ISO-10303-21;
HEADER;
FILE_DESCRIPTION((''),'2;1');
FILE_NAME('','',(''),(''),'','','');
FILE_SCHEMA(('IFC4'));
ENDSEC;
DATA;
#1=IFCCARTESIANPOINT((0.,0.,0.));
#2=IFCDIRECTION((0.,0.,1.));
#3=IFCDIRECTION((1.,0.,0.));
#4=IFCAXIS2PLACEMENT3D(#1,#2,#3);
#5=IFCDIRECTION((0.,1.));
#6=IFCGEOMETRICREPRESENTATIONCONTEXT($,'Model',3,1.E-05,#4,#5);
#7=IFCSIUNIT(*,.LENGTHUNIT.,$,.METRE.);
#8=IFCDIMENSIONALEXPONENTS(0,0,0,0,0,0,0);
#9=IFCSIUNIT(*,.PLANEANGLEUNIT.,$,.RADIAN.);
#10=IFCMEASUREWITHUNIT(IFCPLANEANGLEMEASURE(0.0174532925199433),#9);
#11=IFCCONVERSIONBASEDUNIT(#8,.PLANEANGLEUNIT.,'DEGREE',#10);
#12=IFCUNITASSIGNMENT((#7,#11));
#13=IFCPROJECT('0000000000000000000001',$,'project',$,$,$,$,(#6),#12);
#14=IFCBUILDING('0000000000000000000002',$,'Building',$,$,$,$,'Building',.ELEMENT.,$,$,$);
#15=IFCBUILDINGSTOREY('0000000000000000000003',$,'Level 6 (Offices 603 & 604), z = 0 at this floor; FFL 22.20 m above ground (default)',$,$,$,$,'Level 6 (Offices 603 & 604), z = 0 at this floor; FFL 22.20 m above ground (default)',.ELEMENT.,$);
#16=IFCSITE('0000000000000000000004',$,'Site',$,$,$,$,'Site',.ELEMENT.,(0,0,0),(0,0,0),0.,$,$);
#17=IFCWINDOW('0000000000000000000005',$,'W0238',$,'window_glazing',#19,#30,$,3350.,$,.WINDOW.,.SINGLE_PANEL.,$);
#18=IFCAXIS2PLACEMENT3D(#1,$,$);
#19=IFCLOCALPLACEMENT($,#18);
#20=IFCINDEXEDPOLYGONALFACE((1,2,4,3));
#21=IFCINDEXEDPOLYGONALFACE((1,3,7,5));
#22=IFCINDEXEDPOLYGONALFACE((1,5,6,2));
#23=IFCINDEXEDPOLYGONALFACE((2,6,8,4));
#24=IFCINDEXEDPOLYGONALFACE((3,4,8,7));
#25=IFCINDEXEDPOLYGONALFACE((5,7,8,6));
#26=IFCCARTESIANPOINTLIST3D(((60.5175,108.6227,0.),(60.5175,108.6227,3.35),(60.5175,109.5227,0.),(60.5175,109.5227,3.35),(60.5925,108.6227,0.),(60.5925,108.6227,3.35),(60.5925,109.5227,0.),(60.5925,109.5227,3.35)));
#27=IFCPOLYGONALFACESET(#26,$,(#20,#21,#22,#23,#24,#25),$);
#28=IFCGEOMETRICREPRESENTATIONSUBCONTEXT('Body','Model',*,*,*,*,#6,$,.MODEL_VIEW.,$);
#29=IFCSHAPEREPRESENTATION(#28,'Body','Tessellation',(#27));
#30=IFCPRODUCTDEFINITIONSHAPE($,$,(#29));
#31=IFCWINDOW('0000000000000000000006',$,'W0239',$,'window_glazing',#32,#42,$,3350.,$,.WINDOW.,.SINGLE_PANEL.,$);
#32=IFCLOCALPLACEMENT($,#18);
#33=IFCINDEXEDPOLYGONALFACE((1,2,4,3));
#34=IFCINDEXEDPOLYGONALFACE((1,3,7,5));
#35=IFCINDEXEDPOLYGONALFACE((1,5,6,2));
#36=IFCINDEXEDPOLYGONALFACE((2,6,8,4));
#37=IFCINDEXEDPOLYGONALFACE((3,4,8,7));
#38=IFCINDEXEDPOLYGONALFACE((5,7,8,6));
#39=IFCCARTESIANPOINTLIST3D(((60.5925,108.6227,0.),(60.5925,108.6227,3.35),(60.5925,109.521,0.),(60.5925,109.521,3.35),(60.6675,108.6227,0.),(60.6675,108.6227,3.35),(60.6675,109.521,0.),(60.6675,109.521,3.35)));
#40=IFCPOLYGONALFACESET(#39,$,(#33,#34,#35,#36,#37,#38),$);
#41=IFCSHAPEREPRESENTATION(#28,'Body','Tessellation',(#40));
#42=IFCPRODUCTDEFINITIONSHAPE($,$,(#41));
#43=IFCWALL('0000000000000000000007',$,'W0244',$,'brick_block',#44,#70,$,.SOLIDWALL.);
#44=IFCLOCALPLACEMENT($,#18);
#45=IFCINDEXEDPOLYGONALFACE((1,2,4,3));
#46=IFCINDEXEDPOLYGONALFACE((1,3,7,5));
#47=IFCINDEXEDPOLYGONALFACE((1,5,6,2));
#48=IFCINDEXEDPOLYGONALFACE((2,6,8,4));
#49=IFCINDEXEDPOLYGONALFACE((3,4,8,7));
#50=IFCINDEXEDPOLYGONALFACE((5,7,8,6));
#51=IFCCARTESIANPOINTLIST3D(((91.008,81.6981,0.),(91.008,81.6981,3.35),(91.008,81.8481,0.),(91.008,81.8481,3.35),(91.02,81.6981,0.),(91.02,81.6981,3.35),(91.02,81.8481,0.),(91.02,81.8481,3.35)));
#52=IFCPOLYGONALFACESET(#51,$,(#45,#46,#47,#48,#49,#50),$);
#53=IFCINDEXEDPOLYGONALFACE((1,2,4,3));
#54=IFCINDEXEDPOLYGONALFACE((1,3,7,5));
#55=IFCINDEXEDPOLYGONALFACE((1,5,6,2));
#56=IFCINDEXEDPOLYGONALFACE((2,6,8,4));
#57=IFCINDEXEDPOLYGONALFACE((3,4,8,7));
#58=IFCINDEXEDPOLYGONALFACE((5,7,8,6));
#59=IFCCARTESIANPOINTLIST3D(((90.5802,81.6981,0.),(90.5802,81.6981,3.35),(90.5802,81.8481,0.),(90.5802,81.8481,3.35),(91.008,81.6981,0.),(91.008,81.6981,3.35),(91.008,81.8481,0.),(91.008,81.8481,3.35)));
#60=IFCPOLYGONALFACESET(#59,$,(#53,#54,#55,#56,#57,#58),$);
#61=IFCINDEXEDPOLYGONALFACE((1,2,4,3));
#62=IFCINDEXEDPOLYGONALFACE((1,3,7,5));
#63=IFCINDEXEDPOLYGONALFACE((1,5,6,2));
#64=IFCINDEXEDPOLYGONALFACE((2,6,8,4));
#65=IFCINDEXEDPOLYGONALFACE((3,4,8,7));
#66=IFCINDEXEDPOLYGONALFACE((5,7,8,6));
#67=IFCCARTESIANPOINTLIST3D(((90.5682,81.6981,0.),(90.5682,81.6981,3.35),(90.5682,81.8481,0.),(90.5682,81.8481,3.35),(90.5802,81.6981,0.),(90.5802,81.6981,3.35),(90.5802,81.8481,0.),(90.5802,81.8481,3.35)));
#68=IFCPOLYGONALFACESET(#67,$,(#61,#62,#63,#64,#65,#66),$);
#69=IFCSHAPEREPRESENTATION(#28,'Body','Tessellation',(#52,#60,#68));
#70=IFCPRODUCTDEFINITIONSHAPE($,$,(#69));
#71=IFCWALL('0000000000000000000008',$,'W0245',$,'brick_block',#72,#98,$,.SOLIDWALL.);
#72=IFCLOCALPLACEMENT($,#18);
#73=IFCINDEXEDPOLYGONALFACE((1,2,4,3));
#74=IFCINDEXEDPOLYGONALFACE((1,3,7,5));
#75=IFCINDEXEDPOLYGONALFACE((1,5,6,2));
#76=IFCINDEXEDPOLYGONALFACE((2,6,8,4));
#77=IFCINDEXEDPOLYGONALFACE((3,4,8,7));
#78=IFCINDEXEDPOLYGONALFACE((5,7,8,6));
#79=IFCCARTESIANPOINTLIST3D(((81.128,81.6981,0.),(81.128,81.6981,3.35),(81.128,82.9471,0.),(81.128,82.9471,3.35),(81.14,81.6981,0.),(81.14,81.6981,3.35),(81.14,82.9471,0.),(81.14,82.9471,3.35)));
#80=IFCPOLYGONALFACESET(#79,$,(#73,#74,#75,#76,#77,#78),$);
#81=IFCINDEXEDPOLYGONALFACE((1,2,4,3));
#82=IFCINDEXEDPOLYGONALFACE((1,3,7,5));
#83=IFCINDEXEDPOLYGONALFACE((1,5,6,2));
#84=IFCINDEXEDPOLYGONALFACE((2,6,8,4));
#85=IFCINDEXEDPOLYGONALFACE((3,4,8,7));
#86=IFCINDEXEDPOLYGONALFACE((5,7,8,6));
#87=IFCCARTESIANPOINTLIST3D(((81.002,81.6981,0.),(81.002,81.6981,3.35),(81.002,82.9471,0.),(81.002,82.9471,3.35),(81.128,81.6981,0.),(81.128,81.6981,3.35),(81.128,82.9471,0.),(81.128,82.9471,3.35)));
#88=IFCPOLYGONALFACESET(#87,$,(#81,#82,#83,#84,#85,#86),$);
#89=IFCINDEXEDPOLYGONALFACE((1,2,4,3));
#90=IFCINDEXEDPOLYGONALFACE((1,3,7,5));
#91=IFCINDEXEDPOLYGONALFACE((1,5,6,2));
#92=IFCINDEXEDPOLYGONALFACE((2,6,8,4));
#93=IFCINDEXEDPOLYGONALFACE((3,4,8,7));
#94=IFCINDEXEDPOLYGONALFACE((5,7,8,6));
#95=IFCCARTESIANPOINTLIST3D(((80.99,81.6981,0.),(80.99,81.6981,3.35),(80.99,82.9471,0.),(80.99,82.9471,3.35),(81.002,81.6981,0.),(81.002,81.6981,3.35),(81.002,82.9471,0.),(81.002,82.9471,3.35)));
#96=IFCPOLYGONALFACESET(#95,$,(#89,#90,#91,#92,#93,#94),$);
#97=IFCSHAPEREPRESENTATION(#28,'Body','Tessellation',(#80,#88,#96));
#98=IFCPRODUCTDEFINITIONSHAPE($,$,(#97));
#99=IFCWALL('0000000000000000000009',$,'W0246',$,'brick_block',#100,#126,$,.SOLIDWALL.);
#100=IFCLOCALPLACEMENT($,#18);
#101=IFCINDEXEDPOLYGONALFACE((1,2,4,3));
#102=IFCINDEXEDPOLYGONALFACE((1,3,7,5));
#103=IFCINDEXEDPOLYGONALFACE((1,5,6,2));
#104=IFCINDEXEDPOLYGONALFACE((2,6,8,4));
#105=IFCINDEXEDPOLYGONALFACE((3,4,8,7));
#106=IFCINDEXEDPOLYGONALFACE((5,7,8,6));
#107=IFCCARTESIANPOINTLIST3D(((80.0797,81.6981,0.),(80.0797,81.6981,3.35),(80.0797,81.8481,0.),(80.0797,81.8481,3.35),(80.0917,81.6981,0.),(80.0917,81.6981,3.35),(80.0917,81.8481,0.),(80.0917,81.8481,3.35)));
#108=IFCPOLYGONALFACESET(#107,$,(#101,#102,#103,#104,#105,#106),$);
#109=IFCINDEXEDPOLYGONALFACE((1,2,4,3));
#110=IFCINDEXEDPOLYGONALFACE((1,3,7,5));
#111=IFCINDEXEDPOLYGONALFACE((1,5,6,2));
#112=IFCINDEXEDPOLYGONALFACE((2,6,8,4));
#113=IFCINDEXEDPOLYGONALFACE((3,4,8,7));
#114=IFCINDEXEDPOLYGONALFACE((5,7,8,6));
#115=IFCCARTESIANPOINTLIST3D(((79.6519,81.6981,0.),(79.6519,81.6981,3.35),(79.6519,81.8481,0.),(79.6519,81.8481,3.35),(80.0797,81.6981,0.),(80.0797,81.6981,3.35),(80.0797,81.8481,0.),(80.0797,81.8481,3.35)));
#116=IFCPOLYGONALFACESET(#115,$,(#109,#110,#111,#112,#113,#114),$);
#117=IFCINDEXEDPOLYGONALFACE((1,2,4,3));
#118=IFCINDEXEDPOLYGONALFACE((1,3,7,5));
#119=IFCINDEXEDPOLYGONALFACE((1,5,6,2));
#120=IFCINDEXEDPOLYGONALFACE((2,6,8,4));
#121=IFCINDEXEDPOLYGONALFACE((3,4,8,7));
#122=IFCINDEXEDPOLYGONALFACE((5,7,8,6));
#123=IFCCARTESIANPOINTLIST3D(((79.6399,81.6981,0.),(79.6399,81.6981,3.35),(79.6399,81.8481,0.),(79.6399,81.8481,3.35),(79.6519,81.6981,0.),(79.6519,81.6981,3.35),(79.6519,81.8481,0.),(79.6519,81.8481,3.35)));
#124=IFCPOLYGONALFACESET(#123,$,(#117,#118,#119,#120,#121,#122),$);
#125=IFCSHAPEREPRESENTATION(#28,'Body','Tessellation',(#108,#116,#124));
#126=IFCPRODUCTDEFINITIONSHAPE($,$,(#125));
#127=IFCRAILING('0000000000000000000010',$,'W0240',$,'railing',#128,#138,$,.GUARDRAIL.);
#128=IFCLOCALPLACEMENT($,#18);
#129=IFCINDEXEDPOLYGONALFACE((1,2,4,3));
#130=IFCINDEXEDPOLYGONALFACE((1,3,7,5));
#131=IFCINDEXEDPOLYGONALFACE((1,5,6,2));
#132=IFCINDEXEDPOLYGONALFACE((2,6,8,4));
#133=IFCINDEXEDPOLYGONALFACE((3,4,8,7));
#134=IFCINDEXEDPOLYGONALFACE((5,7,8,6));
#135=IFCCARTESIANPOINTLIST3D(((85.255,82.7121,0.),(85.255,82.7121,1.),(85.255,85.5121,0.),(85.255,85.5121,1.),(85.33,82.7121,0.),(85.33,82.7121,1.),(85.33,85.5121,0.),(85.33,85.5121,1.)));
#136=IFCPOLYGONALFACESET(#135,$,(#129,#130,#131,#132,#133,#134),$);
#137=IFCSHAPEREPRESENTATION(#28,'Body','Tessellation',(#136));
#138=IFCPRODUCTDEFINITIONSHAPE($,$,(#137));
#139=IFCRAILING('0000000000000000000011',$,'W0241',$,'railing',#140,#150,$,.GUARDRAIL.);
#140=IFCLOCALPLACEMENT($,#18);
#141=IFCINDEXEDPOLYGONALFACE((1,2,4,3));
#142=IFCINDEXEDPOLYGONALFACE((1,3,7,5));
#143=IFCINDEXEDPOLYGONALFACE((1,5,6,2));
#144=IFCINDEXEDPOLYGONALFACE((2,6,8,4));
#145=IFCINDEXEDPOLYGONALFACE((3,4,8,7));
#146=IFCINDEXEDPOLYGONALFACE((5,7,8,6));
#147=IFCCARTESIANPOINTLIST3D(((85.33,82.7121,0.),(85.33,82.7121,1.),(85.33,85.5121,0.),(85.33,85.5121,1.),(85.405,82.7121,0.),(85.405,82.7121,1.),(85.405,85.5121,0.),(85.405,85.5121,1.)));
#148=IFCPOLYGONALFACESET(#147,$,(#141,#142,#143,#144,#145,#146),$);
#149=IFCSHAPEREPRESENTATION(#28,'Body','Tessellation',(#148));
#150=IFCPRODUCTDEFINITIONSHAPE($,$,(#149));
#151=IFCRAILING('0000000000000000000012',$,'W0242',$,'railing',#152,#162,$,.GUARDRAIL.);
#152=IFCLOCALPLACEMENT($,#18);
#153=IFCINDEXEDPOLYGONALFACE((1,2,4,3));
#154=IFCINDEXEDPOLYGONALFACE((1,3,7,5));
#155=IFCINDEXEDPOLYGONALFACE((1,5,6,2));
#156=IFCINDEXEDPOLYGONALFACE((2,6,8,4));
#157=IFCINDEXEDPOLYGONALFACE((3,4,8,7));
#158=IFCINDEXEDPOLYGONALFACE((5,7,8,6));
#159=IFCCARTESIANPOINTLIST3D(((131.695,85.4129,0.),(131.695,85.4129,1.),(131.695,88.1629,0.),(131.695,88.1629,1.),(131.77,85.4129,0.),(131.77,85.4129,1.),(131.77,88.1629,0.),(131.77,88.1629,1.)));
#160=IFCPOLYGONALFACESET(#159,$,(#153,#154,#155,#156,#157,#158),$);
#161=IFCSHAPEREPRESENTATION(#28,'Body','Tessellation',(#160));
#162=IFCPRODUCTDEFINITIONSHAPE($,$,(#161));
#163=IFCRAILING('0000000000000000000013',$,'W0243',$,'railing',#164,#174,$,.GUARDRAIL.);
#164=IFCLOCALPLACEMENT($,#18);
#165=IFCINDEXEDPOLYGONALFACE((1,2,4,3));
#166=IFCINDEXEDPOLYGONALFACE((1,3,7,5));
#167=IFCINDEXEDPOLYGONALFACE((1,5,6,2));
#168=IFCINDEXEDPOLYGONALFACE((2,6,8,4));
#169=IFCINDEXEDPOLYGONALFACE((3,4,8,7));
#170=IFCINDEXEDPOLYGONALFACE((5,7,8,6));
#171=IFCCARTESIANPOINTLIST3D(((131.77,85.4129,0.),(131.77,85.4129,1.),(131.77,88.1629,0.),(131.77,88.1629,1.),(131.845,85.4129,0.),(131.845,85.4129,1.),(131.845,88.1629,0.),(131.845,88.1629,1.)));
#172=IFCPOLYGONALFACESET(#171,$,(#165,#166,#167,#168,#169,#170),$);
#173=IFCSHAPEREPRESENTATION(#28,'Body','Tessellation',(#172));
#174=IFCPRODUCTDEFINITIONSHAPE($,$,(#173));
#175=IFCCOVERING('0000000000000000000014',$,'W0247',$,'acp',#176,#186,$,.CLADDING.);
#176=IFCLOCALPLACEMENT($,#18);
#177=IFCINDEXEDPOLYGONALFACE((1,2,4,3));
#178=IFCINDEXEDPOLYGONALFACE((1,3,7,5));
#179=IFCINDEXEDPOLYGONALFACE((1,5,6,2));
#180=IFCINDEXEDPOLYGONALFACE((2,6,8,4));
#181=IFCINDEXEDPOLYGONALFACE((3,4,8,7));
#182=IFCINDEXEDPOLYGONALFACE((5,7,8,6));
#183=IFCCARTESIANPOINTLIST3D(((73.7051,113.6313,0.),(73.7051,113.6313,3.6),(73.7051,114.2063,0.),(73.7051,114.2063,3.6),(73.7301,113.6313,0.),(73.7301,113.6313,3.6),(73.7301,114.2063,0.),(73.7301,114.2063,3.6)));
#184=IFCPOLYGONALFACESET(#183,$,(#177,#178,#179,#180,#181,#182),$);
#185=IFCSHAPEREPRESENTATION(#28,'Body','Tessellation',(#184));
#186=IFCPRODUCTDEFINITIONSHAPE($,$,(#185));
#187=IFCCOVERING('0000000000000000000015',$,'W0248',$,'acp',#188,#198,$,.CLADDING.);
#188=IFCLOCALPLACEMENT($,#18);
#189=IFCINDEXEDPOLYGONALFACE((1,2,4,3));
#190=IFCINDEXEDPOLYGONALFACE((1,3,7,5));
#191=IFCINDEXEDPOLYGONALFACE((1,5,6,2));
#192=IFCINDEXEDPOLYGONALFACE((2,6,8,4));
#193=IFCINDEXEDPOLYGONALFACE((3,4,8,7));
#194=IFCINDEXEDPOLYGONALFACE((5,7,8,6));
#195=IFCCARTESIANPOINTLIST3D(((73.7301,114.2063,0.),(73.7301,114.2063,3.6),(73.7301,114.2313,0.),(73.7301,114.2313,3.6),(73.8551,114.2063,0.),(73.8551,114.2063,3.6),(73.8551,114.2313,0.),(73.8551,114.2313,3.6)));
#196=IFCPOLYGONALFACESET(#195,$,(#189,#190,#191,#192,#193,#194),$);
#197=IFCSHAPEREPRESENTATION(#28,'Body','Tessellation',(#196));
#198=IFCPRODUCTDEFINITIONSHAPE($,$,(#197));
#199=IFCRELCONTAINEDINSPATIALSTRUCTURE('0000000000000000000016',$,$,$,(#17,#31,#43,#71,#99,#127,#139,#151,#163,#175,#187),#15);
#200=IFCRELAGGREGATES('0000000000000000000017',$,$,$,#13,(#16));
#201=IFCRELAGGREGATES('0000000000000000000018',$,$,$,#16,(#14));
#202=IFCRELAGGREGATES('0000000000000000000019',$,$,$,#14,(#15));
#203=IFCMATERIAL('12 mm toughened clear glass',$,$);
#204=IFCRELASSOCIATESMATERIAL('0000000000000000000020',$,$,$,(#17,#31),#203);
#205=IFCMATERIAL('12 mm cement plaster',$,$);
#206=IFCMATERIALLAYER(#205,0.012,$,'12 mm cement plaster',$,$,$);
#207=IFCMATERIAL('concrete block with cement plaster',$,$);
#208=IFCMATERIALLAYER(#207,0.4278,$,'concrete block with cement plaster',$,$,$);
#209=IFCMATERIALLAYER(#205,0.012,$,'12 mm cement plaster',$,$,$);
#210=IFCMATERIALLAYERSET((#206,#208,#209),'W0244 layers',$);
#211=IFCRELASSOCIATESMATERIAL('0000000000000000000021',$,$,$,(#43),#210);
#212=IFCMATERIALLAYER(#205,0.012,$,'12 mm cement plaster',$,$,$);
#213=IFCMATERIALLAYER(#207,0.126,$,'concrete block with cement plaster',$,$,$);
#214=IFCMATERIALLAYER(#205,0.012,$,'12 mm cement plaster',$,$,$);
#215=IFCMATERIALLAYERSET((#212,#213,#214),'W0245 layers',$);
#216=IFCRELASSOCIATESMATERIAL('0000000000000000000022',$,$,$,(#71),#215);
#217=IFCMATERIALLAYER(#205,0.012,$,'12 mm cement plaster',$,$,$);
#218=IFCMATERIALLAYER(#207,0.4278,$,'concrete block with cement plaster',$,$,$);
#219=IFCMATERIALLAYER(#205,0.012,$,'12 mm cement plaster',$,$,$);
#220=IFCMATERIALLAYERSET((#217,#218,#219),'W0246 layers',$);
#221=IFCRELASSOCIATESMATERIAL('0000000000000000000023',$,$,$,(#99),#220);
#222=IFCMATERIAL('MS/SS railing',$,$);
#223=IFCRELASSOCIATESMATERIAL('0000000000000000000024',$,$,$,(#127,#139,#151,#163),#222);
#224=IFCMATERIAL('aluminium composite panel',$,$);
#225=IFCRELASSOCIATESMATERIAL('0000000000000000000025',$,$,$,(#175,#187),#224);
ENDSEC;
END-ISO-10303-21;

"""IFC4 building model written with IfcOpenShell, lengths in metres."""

from ifc_helpers import new_model, entity, si_unit, converted_unit, direction, frame, frame_2d, origin_with_axes, origin_2d_with_axis, place, context, subcontext, project, spatial, rectangle, extrude, material, layer, layer_set, layer_usage, element, save


model = new_model("IFC4")

# Units and contexts
model_context = context("Model", 3, precision=1e-05, world=origin_with_axes(), true_north=direction((0.0, 1.0)))
body_context = subcontext(model_context, "Body", "Model", "MODEL_VIEW")
ifc_project = project(units=[si_unit("LENGTHUNIT", "METRE"), converted_unit("PLANEANGLEUNIT", "DEGREE", entity("IfcPlaneAngleMeasure", 0.0174532925199433), si_unit("PLANEANGLEUNIT", "RADIAN"), dimensions=[0, 0, 0, 0, 0, 0, 0])], contexts=[model_context])

# Site, building, storey
site = spatial("IfcSite", under=ifc_project, Name="Site", LongName="Site", CompositionType="ELEMENT", RefLatitude=(0, 0, 0), RefLongitude=(0, 0, 0), RefElevation=0.0)
building = spatial("IfcBuilding", under=site, Name="Building", LongName="Building", CompositionType="ELEMENT")
storey = spatial("IfcBuildingStorey", under=building, Name="Level 6 (Offices 603 & 604), z = 0 at this floor; FFL 22.20 m above ground (default)", LongName="Level 6 (Offices 603 & 604), z = 0 at this floor; FFL 22.20 m above ground (default)", CompositionType="ELEMENT")

# Shared definitions
ifc_material_1 = material(Name="12 mm toughened clear glass")
placement = place(None, origin_with_axes())

# Shared definitions
ifc_material_2 = material(Name="12 mm cement plaster")
ifc_material_3 = material(Name="concrete block with cement plaster")

# Windows
element("IfcWindow", 1, at=placement, inside=storey, material=ifc_material_1, Name="W0238", ObjectType="window_glazing", OverallHeight=3350.0, PartitioningType="SINGLE_PANEL", PredefinedType="WINDOW", context=body_context, shape_type="SweptSolid", body=[
    extrude(rectangle(XDim=0.9, YDim=0.075, at=frame_2d((0.0, 0.0), x_axis=(0.0, 1.0))), frame((60.555, 109.0727, 0.0), z_axis=(0.0, 0.0, 1.0), x_axis=(1.0, 0.0, 0.0)), (0.0, 0.0, 1.0), 3.35),
])
element("IfcWindow", 2, at=placement, inside=storey, material=ifc_material_1, Name="W0239", ObjectType="window_glazing", OverallHeight=3350.0, PartitioningType="SINGLE_PANEL", PredefinedType="WINDOW", context=body_context, shape_type="SweptSolid", body=[
    extrude(rectangle(XDim=0.8983, YDim=0.075, at=frame_2d((0.0, 0.0), x_axis=(0.0, 1.0))), frame((60.63, 109.0718, 0.0), z_axis=(0.0, 0.0, 1.0), x_axis=(1.0, 0.0, 0.0)), (0.0, 0.0, 1.0), 3.35),
])

# Walls
ifc_layer_1 = layer(ifc_material_2, 0.012, Name="12 mm cement plaster")
ifc_layer_2 = layer(ifc_material_3, 0.4278, Name="concrete block with cement plaster")
ifc_layer_3 = layer(ifc_material_2, 0.012, Name="12 mm cement plaster")
ifc_layer_set_1 = layer_set([ifc_layer_1, ifc_layer_2, ifc_layer_3], Name="W0244 layers")
ifc_layer_usage_1 = layer_usage(ifc_layer_set_1, "AXIS2", "POSITIVE", -0.2259)
element("IfcWall", 3, at=placement, inside=storey, material=ifc_layer_usage_1, Name="W0244", ObjectType="brick_block", PredefinedType="SOLIDWALL", context=body_context, shape_type="SweptSolid", body=[
    extrude(rectangle(XDim=0.15, YDim=0.012, at=frame_2d((0.0, 0.0), x_axis=(0.0, 1.0))), frame((91.014, 81.7731, 0.0), z_axis=(0.0, 0.0, 1.0), x_axis=(1.0, 0.0, 0.0)), (0.0, 0.0, 1.0), 3.35),
    extrude(rectangle(XDim=0.15, YDim=0.4278, at=frame_2d((-0.2199, 0.0), x_axis=(0.0, 1.0))), frame((91.014, 81.7731, 0.0), z_axis=(0.0, 0.0, 1.0), x_axis=(1.0, 0.0, 0.0)), (0.0, 0.0, 1.0), 3.35),
    extrude(rectangle(XDim=0.15, YDim=0.012, at=frame_2d((-0.4398, 0.0), x_axis=(0.0, 1.0))), frame((91.014, 81.7731, 0.0), z_axis=(0.0, 0.0, 1.0), x_axis=(1.0, 0.0, 0.0)), (0.0, 0.0, 1.0), 3.35),
])
ifc_layer_4 = layer(ifc_material_2, 0.012, Name="12 mm cement plaster")
ifc_layer_5 = layer(ifc_material_3, 0.126, Name="concrete block with cement plaster")
ifc_layer_6 = layer(ifc_material_2, 0.012, Name="12 mm cement plaster")
ifc_layer_set_2 = layer_set([ifc_layer_4, ifc_layer_5, ifc_layer_6], Name="W0245 layers")
ifc_layer_usage_2 = layer_usage(ifc_layer_set_2, "AXIS2", "POSITIVE", -0.075)
element("IfcWall", 4, at=placement, inside=storey, material=ifc_layer_usage_2, Name="W0245", ObjectType="brick_block", PredefinedType="SOLIDWALL", context=body_context, shape_type="SweptSolid", body=[
    extrude(rectangle(XDim=1.249, YDim=0.012, at=frame_2d((0.0, 0.0), x_axis=(0.0, 1.0))), frame((81.134, 82.3226, 0.0), z_axis=(0.0, 0.0, 1.0), x_axis=(1.0, 0.0, 0.0)), (0.0, 0.0, 1.0), 3.35),
    extrude(rectangle(XDim=1.249, YDim=0.126, at=frame_2d((-0.069, 0.0), x_axis=(0.0, 1.0))), frame((81.134, 82.3226, 0.0), z_axis=(0.0, 0.0, 1.0), x_axis=(1.0, 0.0, 0.0)), (0.0, 0.0, 1.0), 3.35),
    extrude(rectangle(XDim=1.249, YDim=0.012, at=frame_2d((-0.138, 0.0), x_axis=(0.0, 1.0))), frame((81.134, 82.3226, 0.0), z_axis=(0.0, 0.0, 1.0), x_axis=(1.0, 0.0, 0.0)), (0.0, 0.0, 1.0), 3.35),
])
ifc_layer_7 = layer(ifc_material_2, 0.012, Name="12 mm cement plaster")
ifc_layer_8 = layer(ifc_material_3, 0.4278, Name="concrete block with cement plaster")
ifc_layer_9 = layer(ifc_material_2, 0.012, Name="12 mm cement plaster")
ifc_layer_set_3 = layer_set([ifc_layer_7, ifc_layer_8, ifc_layer_9], Name="W0246 layers")
ifc_layer_usage_3 = layer_usage(ifc_layer_set_3, "AXIS2", "POSITIVE", -0.2259)
element("IfcWall", 5, at=placement, inside=storey, material=ifc_layer_usage_3, Name="W0246", ObjectType="brick_block", PredefinedType="SOLIDWALL", context=body_context, shape_type="SweptSolid", body=[
    extrude(rectangle(XDim=0.15, YDim=0.012, at=frame_2d((0.0, 0.0), x_axis=(0.0, 1.0))), frame((80.0857, 81.7731, 0.0), z_axis=(0.0, 0.0, 1.0), x_axis=(1.0, 0.0, 0.0)), (0.0, 0.0, 1.0), 3.35),
    extrude(rectangle(XDim=0.15, YDim=0.4278, at=frame_2d((-0.2199, 0.0), x_axis=(0.0, 1.0))), frame((80.0857, 81.7731, 0.0), z_axis=(0.0, 0.0, 1.0), x_axis=(1.0, 0.0, 0.0)), (0.0, 0.0, 1.0), 3.35),
    extrude(rectangle(XDim=0.15, YDim=0.012, at=frame_2d((-0.4398, 0.0), x_axis=(0.0, 1.0))), frame((80.0857, 81.7731, 0.0), z_axis=(0.0, 0.0, 1.0), x_axis=(1.0, 0.0, 0.0)), (0.0, 0.0, 1.0), 3.35),
])

# Railings
ifc_material_4 = material(Name="MS/SS railing")
element("IfcRailing", 6, at=placement, inside=storey, material=ifc_material_4, Name="W0240", ObjectType="railing", PredefinedType="GUARDRAIL", context=body_context, shape_type="SweptSolid", body=[
    extrude(rectangle(XDim=2.8, YDim=0.075, at=frame_2d((0.0, 0.0), x_axis=(0.0, 1.0))), frame((85.2925, 84.1121, 0.0), z_axis=(0.0, 0.0, 1.0), x_axis=(1.0, 0.0, 0.0)), (0.0, 0.0, 1.0), 1.0),
])
element("IfcRailing", 7, at=placement, inside=storey, material=ifc_material_4, Name="W0241", ObjectType="railing", PredefinedType="GUARDRAIL", context=body_context, shape_type="SweptSolid", body=[
    extrude(rectangle(XDim=2.8, YDim=0.075, at=frame_2d((0.0, 0.0), x_axis=(0.0, 1.0))), frame((85.3675, 84.1121, 0.0), z_axis=(0.0, 0.0, 1.0), x_axis=(1.0, 0.0, 0.0)), (0.0, 0.0, 1.0), 1.0),
])
element("IfcRailing", 8, at=placement, inside=storey, material=ifc_material_4, Name="W0242", ObjectType="railing", PredefinedType="GUARDRAIL", context=body_context, shape_type="SweptSolid", body=[
    extrude(rectangle(XDim=2.75, YDim=0.075, at=frame_2d((0.0, 0.0), x_axis=(0.0, 1.0))), frame((131.7325, 86.7879, 0.0), z_axis=(0.0, 0.0, 1.0), x_axis=(1.0, 0.0, 0.0)), (0.0, 0.0, 1.0), 1.0),
])
element("IfcRailing", 9, at=placement, inside=storey, material=ifc_material_4, Name="W0243", ObjectType="railing", PredefinedType="GUARDRAIL", context=body_context, shape_type="SweptSolid", body=[
    extrude(rectangle(XDim=2.75, YDim=0.075, at=frame_2d((0.0, 0.0), x_axis=(0.0, 1.0))), frame((131.8075, 86.7879, 0.0), z_axis=(0.0, 0.0, 1.0), x_axis=(1.0, 0.0, 0.0)), (0.0, 0.0, 1.0), 1.0),
])

# Coverings
ifc_material_5 = material(Name="aluminium composite panel")
element("IfcCovering", 10, at=placement, inside=storey, material=ifc_material_5, Name="W0247", ObjectType="acp", PredefinedType="CLADDING", context=body_context, shape_type="SweptSolid", body=[
    extrude(rectangle(XDim=0.575, YDim=0.025, at=frame_2d((0.0, 0.0), x_axis=(0.0, 1.0))), frame((73.7176, 113.9188, 0.0), z_axis=(0.0, 0.0, 1.0), x_axis=(1.0, 0.0, 0.0)), (0.0, 0.0, 1.0), 3.6),
])
element("IfcCovering", 11, at=placement, inside=storey, material=ifc_material_5, Name="W0248", ObjectType="acp", PredefinedType="CLADDING", context=body_context, shape_type="SweptSolid", body=[
    extrude(rectangle(XDim=0.125, YDim=0.025, at=origin_2d_with_axis()), frame((73.7926, 114.2188, 0.0), z_axis=(0.0, 0.0, 1.0), x_axis=(1.0, 0.0, 0.0)), (0.0, 0.0, 1.0), 3.6),
])

save(model, "model.ifc")
